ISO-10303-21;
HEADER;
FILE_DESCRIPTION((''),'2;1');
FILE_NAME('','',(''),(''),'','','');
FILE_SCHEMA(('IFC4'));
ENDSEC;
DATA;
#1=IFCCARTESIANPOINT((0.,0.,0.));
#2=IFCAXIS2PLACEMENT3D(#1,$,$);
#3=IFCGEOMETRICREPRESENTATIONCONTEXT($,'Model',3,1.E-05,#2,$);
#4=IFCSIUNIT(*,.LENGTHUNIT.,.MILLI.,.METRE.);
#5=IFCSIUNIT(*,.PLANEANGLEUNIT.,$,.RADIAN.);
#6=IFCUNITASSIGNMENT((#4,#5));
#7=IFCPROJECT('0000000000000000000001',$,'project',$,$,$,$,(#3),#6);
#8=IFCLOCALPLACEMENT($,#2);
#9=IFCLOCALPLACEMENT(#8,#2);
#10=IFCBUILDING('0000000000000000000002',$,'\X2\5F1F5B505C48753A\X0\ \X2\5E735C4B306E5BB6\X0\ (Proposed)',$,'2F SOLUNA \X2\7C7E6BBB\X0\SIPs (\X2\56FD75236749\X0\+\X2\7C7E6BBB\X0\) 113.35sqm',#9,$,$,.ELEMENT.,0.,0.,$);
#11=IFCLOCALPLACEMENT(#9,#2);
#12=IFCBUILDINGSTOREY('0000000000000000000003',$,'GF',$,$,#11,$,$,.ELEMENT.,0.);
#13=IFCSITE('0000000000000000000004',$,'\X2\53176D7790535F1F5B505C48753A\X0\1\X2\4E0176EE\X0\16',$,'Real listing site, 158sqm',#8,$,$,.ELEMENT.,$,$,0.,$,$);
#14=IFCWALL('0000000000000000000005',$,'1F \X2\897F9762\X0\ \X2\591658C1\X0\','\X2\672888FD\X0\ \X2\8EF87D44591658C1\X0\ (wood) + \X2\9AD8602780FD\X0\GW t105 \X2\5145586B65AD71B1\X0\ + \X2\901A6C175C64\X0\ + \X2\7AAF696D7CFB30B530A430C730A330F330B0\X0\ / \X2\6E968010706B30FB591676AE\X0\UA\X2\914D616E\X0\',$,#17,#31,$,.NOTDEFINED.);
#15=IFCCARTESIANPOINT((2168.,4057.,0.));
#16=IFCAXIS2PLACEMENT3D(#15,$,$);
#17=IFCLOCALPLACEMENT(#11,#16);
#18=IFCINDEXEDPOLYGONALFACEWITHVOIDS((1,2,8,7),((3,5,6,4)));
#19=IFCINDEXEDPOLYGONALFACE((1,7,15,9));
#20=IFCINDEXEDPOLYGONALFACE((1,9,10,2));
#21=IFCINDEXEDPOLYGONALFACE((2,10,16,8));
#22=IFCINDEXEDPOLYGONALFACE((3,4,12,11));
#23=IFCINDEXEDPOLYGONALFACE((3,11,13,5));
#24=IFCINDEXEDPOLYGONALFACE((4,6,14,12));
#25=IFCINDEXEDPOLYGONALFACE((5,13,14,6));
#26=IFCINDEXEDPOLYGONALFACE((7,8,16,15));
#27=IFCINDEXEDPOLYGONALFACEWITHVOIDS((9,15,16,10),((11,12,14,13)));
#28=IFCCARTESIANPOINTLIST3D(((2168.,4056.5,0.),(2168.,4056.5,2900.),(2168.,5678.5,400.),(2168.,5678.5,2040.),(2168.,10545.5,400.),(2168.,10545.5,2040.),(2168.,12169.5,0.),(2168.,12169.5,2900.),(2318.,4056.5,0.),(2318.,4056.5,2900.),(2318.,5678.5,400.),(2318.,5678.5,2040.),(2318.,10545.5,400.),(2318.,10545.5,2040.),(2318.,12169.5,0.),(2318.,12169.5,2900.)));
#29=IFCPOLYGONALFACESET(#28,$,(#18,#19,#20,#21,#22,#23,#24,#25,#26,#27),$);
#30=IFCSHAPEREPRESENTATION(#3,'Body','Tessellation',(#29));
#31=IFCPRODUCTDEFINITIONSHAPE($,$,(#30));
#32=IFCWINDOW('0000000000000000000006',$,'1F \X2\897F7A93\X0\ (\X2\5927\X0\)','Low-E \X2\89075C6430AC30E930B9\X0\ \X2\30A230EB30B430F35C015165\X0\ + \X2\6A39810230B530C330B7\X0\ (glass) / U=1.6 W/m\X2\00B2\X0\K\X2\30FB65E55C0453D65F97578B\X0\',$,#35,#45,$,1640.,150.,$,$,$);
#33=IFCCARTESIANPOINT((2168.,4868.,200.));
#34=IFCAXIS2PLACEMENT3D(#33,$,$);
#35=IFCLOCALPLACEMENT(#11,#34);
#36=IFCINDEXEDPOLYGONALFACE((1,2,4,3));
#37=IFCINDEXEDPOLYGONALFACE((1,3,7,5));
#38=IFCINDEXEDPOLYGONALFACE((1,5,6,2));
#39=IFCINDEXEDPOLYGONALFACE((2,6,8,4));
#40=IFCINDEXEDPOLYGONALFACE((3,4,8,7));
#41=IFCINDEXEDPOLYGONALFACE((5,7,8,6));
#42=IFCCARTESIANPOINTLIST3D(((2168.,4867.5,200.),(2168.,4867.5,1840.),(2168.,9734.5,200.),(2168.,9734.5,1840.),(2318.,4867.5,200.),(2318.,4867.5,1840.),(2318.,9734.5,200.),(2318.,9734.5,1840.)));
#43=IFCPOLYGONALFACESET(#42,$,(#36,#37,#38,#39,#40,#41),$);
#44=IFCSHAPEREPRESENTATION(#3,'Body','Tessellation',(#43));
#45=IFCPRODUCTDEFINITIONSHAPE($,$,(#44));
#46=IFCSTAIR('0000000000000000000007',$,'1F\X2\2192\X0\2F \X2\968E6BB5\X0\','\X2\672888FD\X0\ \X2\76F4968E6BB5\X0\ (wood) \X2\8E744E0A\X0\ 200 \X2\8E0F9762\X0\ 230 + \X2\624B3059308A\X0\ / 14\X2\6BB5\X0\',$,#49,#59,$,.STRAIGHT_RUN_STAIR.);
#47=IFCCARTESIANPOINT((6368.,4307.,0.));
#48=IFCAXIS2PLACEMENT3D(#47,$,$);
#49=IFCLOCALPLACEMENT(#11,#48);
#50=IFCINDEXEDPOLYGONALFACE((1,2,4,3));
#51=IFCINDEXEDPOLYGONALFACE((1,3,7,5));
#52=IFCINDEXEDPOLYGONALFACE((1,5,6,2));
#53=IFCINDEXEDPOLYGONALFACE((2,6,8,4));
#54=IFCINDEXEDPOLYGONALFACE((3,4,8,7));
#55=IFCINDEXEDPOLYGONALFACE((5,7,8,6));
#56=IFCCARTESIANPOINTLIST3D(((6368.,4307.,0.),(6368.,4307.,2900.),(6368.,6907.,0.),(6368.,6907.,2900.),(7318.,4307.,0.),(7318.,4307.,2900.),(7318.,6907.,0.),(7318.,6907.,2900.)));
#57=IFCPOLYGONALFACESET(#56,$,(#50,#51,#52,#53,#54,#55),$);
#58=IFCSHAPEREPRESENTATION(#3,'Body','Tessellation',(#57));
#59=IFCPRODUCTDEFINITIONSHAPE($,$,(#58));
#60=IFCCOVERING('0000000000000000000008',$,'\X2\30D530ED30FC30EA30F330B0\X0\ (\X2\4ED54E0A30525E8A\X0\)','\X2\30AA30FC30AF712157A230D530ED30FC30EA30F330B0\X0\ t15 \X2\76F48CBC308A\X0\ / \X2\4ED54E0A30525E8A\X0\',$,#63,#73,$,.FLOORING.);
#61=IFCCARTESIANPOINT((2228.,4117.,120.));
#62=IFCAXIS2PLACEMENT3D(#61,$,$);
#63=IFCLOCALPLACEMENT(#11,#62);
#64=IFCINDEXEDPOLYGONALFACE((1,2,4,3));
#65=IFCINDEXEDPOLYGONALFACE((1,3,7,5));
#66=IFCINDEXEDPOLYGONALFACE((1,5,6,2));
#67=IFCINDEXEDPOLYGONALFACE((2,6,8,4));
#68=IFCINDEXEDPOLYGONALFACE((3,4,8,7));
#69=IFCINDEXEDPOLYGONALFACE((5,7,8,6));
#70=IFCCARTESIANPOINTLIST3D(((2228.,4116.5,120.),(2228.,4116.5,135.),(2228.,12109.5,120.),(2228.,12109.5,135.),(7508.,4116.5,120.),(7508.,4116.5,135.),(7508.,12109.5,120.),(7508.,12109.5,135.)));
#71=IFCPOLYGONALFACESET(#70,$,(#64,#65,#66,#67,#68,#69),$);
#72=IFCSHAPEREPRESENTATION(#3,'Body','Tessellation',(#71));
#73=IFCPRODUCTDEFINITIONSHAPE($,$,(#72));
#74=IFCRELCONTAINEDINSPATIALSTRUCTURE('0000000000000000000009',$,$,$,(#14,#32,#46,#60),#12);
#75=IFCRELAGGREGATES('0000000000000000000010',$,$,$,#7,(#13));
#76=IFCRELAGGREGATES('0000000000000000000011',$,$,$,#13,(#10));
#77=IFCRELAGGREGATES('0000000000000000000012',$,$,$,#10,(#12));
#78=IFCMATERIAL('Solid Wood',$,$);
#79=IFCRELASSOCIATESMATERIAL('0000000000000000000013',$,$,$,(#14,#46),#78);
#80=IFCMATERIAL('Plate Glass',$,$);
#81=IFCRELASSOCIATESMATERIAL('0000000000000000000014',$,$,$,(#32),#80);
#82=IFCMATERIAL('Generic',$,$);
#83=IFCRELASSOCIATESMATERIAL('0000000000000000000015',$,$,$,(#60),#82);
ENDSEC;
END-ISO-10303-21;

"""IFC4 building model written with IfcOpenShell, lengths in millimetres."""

from ifc_helpers import new_model, si_unit, frame, frame_2d, origin, place, context, project, spatial, rectangle, extrude, material, element, fill, save


model = new_model("IFC4")

# Units and contexts
model_context = context("Model", 3, precision=1e-05, world=origin())
ifc_project = project(units=[si_unit("LENGTHUNIT", "METRE", prefix="MILLI"), si_unit("PLANEANGLEUNIT", "RADIAN")], contexts=[model_context])

# Site, building, storey
site_placement = place(None, origin())
site = spatial("IfcSite", under=ifc_project, at=site_placement, Name="北海道弟子屈町1丁目16", ObjectType="Real listing site, 158sqm", CompositionType="ELEMENT", RefElevation=0.0)
building_placement = place(site_placement, origin())
building = spatial("IfcBuilding", under=site, at=building_placement, Name="弟子屈町 平屋の家 (Proposed)", ObjectType="2F SOLUNA 籾殻SIPs (国産杉+籾殻) 113.35sqm", CompositionType="ELEMENT", ElevationOfRefHeight=0.0, ElevationOfTerrain=0.0)
storey_placement = place(building_placement, origin())
storey = spatial("IfcBuildingStorey", under=building, at=storey_placement, Name="GF", CompositionType="ELEMENT", Elevation=0.0)

# Shared definitions
ifc_material_1 = material(Name="Solid Wood")
ifc_material_2 = material(Name="Generic")

# Shared definitions
ifc_material_3 = material(Name="Plate Glass")

# Wall, opening, window
wall_1_placement = place(storey_placement, frame((2168.0, 4057.0, 0.0)))
wall_1 = element("IfcWall", 1, at=wall_1_placement, inside=storey, material=ifc_material_1, Name="1F 西面 外壁", Description="木製 軸組外壁 (wood) + 高性能GW t105 充填断熱 + 通気層 + 窯業系サイディング / 準耐火・外皮UA配慮", PredefinedType="NOTDEFINED", context=model_context, shape_type="SweptSolid", body=[
    extrude(rectangle(XDim=150.0, YDim=8113.0, at=frame_2d((75.0, 4056.0))), frame((2168.0, 4057.0, 0.0)), (0.0, 0.0, 1.0), 2900.0),
])
opening_1_placement = place(storey_placement, frame((2168.0, 4868.0, 200.0)))
opening_1 = element("IfcOpeningElement", 2, at=opening_1_placement, cuts=wall_1, PredefinedType="NOTDEFINED", context=model_context, shape_type="SweptSolid", body=[
    extrude(rectangle(XDim=150.0, YDim=4867.0, at=frame_2d((75.0, 2433.0))), frame((2168.0, 4868.0, 200.0)), (0.0, 0.0, 1.0), 1640.0),
])
window_1_placement = place(storey_placement, frame((2168.0, 4868.0, 200.0)))
window_1 = element("IfcWindow", 3, at=window_1_placement, inside=storey, material=ifc_material_3, Name="1F 西窓 (大)", Description="Low-E 複層ガラス アルゴン封入 + 樹脂サッシ (glass) / U=1.6 W/m²K・日射取得型", OverallHeight=1640.0, OverallWidth=150.0, context=model_context, shape_type="SweptSolid", body=[
    extrude(rectangle(XDim=150.0, YDim=4867.0, at=frame_2d((75.0, 2433.0))), frame((2168.0, 4868.0, 200.0)), (0.0, 0.0, 1.0), 1640.0),
])
fill(opening_1, window_1)

# Stair
stair_placement = place(storey_placement, frame((6368.0, 4307.0, 0.0)))
element("IfcStair", 4, at=stair_placement, inside=storey, material=ifc_material_1, Name="1F→2F 階段", Description="木製 直階段 (wood) 蹴上 200 踏面 230 + 手すり / 14段", PredefinedType="STRAIGHT_RUN_STAIR", context=model_context, shape_type="SweptSolid", body=[
    extrude(rectangle(XDim=950.0, YDim=2600.0, at=frame_2d((475.0, 1300.0))), frame((6368.0, 4307.0, 0.0)), (0.0, 0.0, 1.0), 2900.0),
])

# Covering
covering_placement = place(storey_placement, frame((2228.0, 4117.0, 120.0)))
element("IfcCovering", 5, at=covering_placement, inside=storey, material=ifc_material_2, Name="フローリング (仕上げ床)", Description="オーク無垢フローリング t15 直貼り / 仕上げ床", PredefinedType="FLOORING", context=model_context, shape_type="SweptSolid", body=[
    extrude(rectangle(XDim=5280.0, YDim=7993.0, at=frame_2d((2640.0, 3996.0))), frame((2228.0, 4117.0, 120.0)), (0.0, 0.0, 1.0), 15.0),
])

save(model, "model.ifc")
